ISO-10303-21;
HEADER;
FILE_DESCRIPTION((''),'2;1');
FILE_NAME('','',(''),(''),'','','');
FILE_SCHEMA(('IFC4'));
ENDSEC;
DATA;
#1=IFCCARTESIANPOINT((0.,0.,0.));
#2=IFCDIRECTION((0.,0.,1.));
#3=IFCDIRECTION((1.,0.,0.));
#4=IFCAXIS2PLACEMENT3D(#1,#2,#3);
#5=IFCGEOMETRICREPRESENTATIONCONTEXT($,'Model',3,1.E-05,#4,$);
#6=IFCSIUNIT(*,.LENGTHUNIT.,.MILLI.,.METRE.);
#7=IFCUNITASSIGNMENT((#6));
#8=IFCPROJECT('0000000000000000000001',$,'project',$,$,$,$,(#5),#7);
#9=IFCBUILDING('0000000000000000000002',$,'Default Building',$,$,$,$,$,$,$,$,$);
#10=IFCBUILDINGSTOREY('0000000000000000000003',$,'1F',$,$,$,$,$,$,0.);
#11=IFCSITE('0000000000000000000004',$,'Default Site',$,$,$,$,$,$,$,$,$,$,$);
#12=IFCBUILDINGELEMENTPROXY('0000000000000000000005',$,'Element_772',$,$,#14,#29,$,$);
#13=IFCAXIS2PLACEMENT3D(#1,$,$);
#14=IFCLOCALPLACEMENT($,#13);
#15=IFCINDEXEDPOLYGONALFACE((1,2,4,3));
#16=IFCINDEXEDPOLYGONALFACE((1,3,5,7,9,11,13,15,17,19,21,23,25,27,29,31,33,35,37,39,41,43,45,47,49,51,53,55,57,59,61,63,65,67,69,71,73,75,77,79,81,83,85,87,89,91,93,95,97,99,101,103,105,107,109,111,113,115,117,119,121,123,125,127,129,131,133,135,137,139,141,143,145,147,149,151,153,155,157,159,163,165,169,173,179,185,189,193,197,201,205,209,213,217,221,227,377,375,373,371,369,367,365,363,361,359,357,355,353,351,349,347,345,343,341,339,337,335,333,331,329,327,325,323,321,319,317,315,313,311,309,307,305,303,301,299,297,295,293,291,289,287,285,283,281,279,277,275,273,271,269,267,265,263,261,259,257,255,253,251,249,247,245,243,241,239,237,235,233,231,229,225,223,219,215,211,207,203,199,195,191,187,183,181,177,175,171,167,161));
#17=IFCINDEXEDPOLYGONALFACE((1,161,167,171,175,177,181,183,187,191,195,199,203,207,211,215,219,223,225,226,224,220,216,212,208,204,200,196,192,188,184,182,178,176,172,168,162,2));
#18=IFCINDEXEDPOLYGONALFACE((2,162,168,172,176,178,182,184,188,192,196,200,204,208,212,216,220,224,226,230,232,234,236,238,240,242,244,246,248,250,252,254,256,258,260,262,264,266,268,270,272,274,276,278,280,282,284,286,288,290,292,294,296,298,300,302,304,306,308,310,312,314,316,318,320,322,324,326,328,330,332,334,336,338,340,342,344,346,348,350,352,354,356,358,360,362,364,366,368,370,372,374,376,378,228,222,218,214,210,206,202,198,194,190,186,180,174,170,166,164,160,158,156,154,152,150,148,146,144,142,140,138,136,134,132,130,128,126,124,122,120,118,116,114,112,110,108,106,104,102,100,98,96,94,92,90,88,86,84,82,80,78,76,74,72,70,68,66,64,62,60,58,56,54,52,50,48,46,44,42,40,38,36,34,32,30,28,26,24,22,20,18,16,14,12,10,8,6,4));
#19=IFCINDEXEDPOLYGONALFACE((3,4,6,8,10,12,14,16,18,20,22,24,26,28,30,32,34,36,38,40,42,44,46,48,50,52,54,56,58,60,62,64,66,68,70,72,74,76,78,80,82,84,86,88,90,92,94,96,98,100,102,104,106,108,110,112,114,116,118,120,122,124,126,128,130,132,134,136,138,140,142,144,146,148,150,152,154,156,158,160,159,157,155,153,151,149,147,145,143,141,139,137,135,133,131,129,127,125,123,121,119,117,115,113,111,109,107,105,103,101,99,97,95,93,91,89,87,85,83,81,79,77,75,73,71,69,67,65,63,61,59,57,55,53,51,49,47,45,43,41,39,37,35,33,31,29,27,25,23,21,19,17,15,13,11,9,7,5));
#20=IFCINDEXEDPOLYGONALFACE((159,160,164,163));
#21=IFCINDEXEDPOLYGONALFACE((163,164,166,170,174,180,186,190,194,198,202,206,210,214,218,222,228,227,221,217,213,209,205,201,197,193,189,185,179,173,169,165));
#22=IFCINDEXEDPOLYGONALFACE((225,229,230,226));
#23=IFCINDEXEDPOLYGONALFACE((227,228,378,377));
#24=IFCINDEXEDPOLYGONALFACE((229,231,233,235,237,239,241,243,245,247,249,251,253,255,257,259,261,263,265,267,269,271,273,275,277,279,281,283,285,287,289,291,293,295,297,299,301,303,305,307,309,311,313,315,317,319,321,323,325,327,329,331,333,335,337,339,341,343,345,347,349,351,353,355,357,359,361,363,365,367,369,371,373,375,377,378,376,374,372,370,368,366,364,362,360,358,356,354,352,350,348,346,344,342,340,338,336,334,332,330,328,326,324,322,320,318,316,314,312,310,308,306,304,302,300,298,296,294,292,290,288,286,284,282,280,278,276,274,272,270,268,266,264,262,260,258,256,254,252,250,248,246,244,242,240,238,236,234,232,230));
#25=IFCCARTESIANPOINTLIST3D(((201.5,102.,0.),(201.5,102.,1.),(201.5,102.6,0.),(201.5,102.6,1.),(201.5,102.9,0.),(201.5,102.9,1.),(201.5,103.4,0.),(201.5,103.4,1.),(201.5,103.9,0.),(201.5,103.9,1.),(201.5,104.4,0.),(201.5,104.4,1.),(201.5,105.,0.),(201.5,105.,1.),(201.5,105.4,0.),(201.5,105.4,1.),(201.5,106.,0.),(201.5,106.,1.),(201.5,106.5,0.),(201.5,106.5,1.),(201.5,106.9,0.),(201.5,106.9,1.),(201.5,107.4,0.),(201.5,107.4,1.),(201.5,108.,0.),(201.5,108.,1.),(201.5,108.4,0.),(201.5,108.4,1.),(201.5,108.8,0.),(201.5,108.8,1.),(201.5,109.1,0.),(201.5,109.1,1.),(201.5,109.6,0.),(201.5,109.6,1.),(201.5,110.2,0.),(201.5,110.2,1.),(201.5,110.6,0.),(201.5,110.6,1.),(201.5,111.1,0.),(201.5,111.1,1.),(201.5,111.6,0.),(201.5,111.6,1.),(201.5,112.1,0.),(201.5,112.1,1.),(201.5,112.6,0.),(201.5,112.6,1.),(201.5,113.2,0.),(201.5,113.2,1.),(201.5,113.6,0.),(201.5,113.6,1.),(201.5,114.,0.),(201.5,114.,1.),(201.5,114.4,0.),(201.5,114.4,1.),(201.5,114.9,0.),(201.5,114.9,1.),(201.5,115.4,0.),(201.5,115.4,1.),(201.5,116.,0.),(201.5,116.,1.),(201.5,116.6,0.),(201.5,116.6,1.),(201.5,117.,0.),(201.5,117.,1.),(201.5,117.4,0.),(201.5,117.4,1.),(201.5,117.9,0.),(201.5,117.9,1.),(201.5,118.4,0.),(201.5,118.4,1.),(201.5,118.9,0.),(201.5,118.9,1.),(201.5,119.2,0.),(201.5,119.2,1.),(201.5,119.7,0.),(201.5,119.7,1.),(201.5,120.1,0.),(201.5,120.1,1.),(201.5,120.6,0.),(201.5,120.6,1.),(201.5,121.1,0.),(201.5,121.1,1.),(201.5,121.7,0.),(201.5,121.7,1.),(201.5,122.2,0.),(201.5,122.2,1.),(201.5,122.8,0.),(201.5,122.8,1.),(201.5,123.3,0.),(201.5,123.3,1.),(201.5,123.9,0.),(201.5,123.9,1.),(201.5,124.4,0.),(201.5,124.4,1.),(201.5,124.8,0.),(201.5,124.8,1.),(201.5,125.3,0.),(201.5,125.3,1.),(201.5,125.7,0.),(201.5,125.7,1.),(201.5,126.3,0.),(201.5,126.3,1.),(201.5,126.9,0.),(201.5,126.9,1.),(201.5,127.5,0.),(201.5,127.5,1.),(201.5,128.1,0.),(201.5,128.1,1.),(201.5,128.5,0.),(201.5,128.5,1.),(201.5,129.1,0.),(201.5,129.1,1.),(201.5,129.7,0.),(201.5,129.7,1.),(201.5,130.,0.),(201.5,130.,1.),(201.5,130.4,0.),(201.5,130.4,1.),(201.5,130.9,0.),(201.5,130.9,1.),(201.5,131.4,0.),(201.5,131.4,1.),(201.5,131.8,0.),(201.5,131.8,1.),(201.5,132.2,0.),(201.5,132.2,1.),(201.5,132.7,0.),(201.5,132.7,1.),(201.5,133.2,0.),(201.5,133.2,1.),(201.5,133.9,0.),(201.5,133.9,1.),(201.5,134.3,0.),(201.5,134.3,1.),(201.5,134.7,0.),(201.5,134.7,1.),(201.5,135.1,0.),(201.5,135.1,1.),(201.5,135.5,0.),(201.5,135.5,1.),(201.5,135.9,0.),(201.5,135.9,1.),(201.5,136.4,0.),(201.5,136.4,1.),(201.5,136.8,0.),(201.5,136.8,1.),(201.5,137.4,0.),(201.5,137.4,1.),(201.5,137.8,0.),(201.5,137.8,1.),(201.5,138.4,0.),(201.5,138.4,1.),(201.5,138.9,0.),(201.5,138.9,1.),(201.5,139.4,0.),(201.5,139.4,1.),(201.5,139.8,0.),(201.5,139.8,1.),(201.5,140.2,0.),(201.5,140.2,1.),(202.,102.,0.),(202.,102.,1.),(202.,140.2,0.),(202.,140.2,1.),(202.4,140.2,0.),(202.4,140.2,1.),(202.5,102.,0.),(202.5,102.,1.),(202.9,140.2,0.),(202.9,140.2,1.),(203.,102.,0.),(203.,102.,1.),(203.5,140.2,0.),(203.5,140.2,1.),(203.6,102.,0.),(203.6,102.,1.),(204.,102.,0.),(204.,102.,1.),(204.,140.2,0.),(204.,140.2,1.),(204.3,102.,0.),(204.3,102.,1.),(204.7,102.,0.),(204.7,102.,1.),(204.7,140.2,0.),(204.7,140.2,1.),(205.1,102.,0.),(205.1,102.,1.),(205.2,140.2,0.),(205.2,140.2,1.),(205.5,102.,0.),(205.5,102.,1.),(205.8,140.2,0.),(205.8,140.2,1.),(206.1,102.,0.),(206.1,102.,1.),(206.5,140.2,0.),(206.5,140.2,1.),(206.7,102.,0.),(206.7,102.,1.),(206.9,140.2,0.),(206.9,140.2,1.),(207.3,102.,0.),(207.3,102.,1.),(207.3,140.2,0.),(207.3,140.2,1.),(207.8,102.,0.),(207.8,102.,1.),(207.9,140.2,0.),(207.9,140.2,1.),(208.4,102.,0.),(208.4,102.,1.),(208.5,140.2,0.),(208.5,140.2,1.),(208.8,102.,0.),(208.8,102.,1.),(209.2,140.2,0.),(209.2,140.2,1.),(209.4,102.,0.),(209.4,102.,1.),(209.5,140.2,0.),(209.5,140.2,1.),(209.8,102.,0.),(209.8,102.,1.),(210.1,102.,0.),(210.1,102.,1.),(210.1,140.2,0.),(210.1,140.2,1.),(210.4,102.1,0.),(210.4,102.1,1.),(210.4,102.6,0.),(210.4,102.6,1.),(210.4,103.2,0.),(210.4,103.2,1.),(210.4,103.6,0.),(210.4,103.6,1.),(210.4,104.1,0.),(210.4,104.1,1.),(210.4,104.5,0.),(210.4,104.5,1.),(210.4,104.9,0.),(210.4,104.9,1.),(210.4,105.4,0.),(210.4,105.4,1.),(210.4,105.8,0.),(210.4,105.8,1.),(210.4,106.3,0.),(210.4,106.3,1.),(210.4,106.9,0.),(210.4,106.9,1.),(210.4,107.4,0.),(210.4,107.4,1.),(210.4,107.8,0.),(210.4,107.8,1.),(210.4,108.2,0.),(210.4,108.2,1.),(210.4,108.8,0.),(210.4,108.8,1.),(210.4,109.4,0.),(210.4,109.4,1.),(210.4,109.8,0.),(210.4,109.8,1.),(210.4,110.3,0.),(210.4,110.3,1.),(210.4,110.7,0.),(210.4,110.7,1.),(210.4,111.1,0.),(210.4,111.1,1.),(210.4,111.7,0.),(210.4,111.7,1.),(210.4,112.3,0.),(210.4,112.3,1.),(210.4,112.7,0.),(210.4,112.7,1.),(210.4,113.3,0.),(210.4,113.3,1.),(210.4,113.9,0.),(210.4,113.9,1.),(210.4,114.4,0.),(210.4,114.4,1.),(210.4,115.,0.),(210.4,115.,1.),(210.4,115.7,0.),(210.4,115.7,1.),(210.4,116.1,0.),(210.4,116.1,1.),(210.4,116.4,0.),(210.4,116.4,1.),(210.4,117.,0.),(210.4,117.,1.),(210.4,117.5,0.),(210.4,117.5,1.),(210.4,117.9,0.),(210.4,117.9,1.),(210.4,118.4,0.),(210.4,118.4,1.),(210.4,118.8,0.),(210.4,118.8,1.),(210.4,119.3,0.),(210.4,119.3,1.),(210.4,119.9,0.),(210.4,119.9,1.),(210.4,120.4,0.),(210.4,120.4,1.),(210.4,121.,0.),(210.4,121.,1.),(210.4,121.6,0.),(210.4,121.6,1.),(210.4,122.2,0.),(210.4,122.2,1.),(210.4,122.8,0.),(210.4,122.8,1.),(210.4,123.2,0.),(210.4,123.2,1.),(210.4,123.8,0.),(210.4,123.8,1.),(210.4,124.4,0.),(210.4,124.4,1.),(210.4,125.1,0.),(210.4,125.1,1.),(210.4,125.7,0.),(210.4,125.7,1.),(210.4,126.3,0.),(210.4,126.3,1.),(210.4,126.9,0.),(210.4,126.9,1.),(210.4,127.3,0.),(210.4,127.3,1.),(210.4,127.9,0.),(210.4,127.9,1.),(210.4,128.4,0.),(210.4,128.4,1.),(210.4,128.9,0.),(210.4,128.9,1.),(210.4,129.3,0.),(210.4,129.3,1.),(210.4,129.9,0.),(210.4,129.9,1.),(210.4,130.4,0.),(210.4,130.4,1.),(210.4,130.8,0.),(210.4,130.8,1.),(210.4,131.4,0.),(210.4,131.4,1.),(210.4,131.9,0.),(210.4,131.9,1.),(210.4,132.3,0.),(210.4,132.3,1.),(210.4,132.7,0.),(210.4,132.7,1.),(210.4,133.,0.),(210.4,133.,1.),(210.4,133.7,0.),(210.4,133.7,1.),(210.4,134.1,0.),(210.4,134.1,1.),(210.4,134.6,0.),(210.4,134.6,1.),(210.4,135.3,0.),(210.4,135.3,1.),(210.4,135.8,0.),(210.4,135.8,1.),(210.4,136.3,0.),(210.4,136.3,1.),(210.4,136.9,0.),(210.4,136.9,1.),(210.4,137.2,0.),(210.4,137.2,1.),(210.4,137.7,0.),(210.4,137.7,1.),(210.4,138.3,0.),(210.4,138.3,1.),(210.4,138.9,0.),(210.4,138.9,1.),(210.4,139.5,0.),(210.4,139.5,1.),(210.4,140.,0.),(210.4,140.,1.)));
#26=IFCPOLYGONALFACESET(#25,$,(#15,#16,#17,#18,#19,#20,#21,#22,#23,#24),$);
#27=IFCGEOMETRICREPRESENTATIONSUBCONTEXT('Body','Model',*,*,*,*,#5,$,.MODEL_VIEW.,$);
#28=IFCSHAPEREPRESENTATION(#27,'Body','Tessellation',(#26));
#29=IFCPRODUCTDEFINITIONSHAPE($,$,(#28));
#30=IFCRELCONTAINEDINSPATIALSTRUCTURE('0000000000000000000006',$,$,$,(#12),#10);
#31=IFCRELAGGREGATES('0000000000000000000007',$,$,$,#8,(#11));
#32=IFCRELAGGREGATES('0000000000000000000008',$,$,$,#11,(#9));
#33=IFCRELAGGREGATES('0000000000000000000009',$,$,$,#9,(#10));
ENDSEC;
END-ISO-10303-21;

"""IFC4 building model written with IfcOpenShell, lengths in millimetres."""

from ifc_helpers import new_model, si_unit, frame, origin, origin_with_axes, place, context, subcontext, project, spatial, polyline, outline, extrude, element, save


model = new_model("IFC4")

# Units and contexts
model_context = context("Model", 3, precision=1e-05, world=origin_with_axes())
body_context = subcontext(model_context, "Body", "Model", "MODEL_VIEW")
ifc_project = project(units=[si_unit("LENGTHUNIT", "METRE", prefix="MILLI")], contexts=[model_context])

# Site, building, storey
site = spatial("IfcSite", under=ifc_project, Name="Default Site")
building = spatial("IfcBuilding", under=site, Name="Default Building")
storey = spatial("IfcBuildingStorey", under=building, Name="1F", Elevation=0.0)

# Building element proxy
proxy_1_placement = place(None, frame((205.8, 120.9, 0.0), z_axis=(0.0, 0.0, 1.0), x_axis=(1.0, 0.0, 0.0)))
element("IfcBuildingElementProxy", 1, at=proxy_1_placement, inside=storey, Name="Element_772", context=body_context, shape_type="SweptSolid", body=[
    extrude(outline(polyline([(-4.3, 19.3), (-3.8, 19.3), (-3.4, 19.3), (-3.0, 19.3), (-2.3, 19.3), (-1.8, 19.3), (-1.1, 19.3), (-0.7, 19.3), (0.0, 19.3), (0.6, 19.3), (1.1, 19.3), (1.5, 19.3), (2.1, 19.3), (2.7, 19.3), (3.3, 19.3), (3.7, 19.3), (4.3, 19.3), (4.6, 19.1), (4.6, 18.6), (4.6, 18.0), (4.6, 17.4), (4.6, 16.8), (4.6, 16.3), (4.6, 15.9), (4.6, 15.4), (4.6, 14.9), (4.6, 14.3), (4.6, 13.7), (4.6, 13.1), (4.6, 12.8), (4.6, 12.1), (4.6, 11.7), (4.6, 11.4), (4.6, 11.0), (4.6, 10.4), (4.6, 9.9), (4.6, 9.5), (4.6, 9.0), (4.6, 8.4), (4.6, 7.9), (4.6, 7.5), (4.6, 7.0), (4.6, 6.4), (4.6, 6.0), (4.6, 5.4), (4.6, 4.8), (4.6, 4.2), (4.6, 3.5), (4.6, 2.9), (4.6, 2.3), (4.6, 1.8), (4.6, 1.3), (4.6, 0.7), (4.6, 0.1), (4.6, -0.5), (4.6, -1.0), (4.6, -1.6), (4.6, -2.1), (4.6, -2.5), (4.6, -3.0), (4.6, -3.4), (4.6, -3.9), (4.6, -4.5), (4.6, -4.8), (4.6, -5.2), (4.6, -5.9), (4.6, -6.5), (4.6, -7.0), (4.6, -7.6), (4.6, -8.2), (4.6, -8.6), (4.6, -9.2), (4.6, -9.8), (4.6, -10.2), (4.6, -10.7), (4.6, -11.1), (4.6, -11.5), (4.6, -12.1), (4.6, -12.7), (4.6, -13.1), (4.6, -13.5), (4.6, -14.0), (4.6, -14.6), (4.6, -15.1), (4.6, -15.5), (4.6, -16.0), (4.6, -16.5), (4.6, -16.8), (4.6, -17.3), (4.6, -17.7), (4.6, -18.3), (4.6, -18.8), (4.3, -18.9), (4.0, -18.9), (3.6, -18.9), (3.0, -18.9), (2.6, -18.9), (2.0, -18.9), (1.5, -18.9), (0.9, -18.9), (0.3, -18.9), (-0.4, -18.9), (-0.7, -18.9), (-1.1, -18.9), (-1.5, -18.9), (-1.9, -18.9), (-2.2, -18.9), (-2.8, -18.9), (-3.4, -18.9), (-3.8, -18.9), (-4.3, -18.9), (-4.3, -18.4), (-4.3, -18.0), (-4.3, -17.5), (-4.3, -17.0), (-4.3, -16.5), (-4.3, -15.9), (-4.3, -15.5), (-4.3, -14.9), (-4.3, -14.4), (-4.3, -14.0), (-4.3, -13.5), (-4.3, -13.0), (-4.3, -12.5), (-4.3, -12.1), (-4.3, -11.8), (-4.3, -11.3), (-4.3, -10.7), (-4.3, -10.3), (-4.3, -9.8), (-4.3, -9.3), (-4.3, -8.8), (-4.3, -8.3), (-4.3, -7.7), (-4.3, -7.3), (-4.3, -6.9), (-4.3, -6.5), (-4.3, -6.0), (-4.3, -5.5), (-4.3, -4.9), (-4.3, -4.3), (-4.3, -3.9), (-4.3, -3.5), (-4.3, -3.0), (-4.3, -2.6), (-4.3, -2.0), (-4.3, -1.7), (-4.3, -1.2), (-4.3, -0.8), (-4.3, -0.3), (-4.3, 0.2), (-4.3, 0.8), (-4.3, 1.2), (-4.3, 1.9), (-4.3, 2.4), (-4.3, 3.0), (-4.3, 3.5), (-4.3, 3.9), (-4.3, 4.4), (-4.3, 4.8), (-4.3, 5.4), (-4.3, 6.0), (-4.3, 6.6), (-4.3, 7.1), (-4.3, 7.6), (-4.3, 8.2), (-4.3, 8.8), (-4.3, 9.1), (-4.3, 9.5), (-4.3, 10.0), (-4.3, 10.5), (-4.3, 10.9), (-4.3, 11.3), (-4.3, 11.8), (-4.3, 12.3), (-4.3, 13.0), (-4.3, 13.4), (-4.3, 13.8), (-4.3, 14.2), (-4.3, 14.6), (-4.3, 15.0), (-4.3, 15.4), (-4.3, 15.9), (-4.3, 16.5), (-4.3, 16.9), (-4.3, 17.5), (-4.3, 18.0), (-4.3, 18.5), (-4.3, 18.9), (-4.3, 19.3), (-4.3, 19.3)])), origin(), (0.0, 0.0, 1.0), 1.0),
])

save(model, "model.ifc")
